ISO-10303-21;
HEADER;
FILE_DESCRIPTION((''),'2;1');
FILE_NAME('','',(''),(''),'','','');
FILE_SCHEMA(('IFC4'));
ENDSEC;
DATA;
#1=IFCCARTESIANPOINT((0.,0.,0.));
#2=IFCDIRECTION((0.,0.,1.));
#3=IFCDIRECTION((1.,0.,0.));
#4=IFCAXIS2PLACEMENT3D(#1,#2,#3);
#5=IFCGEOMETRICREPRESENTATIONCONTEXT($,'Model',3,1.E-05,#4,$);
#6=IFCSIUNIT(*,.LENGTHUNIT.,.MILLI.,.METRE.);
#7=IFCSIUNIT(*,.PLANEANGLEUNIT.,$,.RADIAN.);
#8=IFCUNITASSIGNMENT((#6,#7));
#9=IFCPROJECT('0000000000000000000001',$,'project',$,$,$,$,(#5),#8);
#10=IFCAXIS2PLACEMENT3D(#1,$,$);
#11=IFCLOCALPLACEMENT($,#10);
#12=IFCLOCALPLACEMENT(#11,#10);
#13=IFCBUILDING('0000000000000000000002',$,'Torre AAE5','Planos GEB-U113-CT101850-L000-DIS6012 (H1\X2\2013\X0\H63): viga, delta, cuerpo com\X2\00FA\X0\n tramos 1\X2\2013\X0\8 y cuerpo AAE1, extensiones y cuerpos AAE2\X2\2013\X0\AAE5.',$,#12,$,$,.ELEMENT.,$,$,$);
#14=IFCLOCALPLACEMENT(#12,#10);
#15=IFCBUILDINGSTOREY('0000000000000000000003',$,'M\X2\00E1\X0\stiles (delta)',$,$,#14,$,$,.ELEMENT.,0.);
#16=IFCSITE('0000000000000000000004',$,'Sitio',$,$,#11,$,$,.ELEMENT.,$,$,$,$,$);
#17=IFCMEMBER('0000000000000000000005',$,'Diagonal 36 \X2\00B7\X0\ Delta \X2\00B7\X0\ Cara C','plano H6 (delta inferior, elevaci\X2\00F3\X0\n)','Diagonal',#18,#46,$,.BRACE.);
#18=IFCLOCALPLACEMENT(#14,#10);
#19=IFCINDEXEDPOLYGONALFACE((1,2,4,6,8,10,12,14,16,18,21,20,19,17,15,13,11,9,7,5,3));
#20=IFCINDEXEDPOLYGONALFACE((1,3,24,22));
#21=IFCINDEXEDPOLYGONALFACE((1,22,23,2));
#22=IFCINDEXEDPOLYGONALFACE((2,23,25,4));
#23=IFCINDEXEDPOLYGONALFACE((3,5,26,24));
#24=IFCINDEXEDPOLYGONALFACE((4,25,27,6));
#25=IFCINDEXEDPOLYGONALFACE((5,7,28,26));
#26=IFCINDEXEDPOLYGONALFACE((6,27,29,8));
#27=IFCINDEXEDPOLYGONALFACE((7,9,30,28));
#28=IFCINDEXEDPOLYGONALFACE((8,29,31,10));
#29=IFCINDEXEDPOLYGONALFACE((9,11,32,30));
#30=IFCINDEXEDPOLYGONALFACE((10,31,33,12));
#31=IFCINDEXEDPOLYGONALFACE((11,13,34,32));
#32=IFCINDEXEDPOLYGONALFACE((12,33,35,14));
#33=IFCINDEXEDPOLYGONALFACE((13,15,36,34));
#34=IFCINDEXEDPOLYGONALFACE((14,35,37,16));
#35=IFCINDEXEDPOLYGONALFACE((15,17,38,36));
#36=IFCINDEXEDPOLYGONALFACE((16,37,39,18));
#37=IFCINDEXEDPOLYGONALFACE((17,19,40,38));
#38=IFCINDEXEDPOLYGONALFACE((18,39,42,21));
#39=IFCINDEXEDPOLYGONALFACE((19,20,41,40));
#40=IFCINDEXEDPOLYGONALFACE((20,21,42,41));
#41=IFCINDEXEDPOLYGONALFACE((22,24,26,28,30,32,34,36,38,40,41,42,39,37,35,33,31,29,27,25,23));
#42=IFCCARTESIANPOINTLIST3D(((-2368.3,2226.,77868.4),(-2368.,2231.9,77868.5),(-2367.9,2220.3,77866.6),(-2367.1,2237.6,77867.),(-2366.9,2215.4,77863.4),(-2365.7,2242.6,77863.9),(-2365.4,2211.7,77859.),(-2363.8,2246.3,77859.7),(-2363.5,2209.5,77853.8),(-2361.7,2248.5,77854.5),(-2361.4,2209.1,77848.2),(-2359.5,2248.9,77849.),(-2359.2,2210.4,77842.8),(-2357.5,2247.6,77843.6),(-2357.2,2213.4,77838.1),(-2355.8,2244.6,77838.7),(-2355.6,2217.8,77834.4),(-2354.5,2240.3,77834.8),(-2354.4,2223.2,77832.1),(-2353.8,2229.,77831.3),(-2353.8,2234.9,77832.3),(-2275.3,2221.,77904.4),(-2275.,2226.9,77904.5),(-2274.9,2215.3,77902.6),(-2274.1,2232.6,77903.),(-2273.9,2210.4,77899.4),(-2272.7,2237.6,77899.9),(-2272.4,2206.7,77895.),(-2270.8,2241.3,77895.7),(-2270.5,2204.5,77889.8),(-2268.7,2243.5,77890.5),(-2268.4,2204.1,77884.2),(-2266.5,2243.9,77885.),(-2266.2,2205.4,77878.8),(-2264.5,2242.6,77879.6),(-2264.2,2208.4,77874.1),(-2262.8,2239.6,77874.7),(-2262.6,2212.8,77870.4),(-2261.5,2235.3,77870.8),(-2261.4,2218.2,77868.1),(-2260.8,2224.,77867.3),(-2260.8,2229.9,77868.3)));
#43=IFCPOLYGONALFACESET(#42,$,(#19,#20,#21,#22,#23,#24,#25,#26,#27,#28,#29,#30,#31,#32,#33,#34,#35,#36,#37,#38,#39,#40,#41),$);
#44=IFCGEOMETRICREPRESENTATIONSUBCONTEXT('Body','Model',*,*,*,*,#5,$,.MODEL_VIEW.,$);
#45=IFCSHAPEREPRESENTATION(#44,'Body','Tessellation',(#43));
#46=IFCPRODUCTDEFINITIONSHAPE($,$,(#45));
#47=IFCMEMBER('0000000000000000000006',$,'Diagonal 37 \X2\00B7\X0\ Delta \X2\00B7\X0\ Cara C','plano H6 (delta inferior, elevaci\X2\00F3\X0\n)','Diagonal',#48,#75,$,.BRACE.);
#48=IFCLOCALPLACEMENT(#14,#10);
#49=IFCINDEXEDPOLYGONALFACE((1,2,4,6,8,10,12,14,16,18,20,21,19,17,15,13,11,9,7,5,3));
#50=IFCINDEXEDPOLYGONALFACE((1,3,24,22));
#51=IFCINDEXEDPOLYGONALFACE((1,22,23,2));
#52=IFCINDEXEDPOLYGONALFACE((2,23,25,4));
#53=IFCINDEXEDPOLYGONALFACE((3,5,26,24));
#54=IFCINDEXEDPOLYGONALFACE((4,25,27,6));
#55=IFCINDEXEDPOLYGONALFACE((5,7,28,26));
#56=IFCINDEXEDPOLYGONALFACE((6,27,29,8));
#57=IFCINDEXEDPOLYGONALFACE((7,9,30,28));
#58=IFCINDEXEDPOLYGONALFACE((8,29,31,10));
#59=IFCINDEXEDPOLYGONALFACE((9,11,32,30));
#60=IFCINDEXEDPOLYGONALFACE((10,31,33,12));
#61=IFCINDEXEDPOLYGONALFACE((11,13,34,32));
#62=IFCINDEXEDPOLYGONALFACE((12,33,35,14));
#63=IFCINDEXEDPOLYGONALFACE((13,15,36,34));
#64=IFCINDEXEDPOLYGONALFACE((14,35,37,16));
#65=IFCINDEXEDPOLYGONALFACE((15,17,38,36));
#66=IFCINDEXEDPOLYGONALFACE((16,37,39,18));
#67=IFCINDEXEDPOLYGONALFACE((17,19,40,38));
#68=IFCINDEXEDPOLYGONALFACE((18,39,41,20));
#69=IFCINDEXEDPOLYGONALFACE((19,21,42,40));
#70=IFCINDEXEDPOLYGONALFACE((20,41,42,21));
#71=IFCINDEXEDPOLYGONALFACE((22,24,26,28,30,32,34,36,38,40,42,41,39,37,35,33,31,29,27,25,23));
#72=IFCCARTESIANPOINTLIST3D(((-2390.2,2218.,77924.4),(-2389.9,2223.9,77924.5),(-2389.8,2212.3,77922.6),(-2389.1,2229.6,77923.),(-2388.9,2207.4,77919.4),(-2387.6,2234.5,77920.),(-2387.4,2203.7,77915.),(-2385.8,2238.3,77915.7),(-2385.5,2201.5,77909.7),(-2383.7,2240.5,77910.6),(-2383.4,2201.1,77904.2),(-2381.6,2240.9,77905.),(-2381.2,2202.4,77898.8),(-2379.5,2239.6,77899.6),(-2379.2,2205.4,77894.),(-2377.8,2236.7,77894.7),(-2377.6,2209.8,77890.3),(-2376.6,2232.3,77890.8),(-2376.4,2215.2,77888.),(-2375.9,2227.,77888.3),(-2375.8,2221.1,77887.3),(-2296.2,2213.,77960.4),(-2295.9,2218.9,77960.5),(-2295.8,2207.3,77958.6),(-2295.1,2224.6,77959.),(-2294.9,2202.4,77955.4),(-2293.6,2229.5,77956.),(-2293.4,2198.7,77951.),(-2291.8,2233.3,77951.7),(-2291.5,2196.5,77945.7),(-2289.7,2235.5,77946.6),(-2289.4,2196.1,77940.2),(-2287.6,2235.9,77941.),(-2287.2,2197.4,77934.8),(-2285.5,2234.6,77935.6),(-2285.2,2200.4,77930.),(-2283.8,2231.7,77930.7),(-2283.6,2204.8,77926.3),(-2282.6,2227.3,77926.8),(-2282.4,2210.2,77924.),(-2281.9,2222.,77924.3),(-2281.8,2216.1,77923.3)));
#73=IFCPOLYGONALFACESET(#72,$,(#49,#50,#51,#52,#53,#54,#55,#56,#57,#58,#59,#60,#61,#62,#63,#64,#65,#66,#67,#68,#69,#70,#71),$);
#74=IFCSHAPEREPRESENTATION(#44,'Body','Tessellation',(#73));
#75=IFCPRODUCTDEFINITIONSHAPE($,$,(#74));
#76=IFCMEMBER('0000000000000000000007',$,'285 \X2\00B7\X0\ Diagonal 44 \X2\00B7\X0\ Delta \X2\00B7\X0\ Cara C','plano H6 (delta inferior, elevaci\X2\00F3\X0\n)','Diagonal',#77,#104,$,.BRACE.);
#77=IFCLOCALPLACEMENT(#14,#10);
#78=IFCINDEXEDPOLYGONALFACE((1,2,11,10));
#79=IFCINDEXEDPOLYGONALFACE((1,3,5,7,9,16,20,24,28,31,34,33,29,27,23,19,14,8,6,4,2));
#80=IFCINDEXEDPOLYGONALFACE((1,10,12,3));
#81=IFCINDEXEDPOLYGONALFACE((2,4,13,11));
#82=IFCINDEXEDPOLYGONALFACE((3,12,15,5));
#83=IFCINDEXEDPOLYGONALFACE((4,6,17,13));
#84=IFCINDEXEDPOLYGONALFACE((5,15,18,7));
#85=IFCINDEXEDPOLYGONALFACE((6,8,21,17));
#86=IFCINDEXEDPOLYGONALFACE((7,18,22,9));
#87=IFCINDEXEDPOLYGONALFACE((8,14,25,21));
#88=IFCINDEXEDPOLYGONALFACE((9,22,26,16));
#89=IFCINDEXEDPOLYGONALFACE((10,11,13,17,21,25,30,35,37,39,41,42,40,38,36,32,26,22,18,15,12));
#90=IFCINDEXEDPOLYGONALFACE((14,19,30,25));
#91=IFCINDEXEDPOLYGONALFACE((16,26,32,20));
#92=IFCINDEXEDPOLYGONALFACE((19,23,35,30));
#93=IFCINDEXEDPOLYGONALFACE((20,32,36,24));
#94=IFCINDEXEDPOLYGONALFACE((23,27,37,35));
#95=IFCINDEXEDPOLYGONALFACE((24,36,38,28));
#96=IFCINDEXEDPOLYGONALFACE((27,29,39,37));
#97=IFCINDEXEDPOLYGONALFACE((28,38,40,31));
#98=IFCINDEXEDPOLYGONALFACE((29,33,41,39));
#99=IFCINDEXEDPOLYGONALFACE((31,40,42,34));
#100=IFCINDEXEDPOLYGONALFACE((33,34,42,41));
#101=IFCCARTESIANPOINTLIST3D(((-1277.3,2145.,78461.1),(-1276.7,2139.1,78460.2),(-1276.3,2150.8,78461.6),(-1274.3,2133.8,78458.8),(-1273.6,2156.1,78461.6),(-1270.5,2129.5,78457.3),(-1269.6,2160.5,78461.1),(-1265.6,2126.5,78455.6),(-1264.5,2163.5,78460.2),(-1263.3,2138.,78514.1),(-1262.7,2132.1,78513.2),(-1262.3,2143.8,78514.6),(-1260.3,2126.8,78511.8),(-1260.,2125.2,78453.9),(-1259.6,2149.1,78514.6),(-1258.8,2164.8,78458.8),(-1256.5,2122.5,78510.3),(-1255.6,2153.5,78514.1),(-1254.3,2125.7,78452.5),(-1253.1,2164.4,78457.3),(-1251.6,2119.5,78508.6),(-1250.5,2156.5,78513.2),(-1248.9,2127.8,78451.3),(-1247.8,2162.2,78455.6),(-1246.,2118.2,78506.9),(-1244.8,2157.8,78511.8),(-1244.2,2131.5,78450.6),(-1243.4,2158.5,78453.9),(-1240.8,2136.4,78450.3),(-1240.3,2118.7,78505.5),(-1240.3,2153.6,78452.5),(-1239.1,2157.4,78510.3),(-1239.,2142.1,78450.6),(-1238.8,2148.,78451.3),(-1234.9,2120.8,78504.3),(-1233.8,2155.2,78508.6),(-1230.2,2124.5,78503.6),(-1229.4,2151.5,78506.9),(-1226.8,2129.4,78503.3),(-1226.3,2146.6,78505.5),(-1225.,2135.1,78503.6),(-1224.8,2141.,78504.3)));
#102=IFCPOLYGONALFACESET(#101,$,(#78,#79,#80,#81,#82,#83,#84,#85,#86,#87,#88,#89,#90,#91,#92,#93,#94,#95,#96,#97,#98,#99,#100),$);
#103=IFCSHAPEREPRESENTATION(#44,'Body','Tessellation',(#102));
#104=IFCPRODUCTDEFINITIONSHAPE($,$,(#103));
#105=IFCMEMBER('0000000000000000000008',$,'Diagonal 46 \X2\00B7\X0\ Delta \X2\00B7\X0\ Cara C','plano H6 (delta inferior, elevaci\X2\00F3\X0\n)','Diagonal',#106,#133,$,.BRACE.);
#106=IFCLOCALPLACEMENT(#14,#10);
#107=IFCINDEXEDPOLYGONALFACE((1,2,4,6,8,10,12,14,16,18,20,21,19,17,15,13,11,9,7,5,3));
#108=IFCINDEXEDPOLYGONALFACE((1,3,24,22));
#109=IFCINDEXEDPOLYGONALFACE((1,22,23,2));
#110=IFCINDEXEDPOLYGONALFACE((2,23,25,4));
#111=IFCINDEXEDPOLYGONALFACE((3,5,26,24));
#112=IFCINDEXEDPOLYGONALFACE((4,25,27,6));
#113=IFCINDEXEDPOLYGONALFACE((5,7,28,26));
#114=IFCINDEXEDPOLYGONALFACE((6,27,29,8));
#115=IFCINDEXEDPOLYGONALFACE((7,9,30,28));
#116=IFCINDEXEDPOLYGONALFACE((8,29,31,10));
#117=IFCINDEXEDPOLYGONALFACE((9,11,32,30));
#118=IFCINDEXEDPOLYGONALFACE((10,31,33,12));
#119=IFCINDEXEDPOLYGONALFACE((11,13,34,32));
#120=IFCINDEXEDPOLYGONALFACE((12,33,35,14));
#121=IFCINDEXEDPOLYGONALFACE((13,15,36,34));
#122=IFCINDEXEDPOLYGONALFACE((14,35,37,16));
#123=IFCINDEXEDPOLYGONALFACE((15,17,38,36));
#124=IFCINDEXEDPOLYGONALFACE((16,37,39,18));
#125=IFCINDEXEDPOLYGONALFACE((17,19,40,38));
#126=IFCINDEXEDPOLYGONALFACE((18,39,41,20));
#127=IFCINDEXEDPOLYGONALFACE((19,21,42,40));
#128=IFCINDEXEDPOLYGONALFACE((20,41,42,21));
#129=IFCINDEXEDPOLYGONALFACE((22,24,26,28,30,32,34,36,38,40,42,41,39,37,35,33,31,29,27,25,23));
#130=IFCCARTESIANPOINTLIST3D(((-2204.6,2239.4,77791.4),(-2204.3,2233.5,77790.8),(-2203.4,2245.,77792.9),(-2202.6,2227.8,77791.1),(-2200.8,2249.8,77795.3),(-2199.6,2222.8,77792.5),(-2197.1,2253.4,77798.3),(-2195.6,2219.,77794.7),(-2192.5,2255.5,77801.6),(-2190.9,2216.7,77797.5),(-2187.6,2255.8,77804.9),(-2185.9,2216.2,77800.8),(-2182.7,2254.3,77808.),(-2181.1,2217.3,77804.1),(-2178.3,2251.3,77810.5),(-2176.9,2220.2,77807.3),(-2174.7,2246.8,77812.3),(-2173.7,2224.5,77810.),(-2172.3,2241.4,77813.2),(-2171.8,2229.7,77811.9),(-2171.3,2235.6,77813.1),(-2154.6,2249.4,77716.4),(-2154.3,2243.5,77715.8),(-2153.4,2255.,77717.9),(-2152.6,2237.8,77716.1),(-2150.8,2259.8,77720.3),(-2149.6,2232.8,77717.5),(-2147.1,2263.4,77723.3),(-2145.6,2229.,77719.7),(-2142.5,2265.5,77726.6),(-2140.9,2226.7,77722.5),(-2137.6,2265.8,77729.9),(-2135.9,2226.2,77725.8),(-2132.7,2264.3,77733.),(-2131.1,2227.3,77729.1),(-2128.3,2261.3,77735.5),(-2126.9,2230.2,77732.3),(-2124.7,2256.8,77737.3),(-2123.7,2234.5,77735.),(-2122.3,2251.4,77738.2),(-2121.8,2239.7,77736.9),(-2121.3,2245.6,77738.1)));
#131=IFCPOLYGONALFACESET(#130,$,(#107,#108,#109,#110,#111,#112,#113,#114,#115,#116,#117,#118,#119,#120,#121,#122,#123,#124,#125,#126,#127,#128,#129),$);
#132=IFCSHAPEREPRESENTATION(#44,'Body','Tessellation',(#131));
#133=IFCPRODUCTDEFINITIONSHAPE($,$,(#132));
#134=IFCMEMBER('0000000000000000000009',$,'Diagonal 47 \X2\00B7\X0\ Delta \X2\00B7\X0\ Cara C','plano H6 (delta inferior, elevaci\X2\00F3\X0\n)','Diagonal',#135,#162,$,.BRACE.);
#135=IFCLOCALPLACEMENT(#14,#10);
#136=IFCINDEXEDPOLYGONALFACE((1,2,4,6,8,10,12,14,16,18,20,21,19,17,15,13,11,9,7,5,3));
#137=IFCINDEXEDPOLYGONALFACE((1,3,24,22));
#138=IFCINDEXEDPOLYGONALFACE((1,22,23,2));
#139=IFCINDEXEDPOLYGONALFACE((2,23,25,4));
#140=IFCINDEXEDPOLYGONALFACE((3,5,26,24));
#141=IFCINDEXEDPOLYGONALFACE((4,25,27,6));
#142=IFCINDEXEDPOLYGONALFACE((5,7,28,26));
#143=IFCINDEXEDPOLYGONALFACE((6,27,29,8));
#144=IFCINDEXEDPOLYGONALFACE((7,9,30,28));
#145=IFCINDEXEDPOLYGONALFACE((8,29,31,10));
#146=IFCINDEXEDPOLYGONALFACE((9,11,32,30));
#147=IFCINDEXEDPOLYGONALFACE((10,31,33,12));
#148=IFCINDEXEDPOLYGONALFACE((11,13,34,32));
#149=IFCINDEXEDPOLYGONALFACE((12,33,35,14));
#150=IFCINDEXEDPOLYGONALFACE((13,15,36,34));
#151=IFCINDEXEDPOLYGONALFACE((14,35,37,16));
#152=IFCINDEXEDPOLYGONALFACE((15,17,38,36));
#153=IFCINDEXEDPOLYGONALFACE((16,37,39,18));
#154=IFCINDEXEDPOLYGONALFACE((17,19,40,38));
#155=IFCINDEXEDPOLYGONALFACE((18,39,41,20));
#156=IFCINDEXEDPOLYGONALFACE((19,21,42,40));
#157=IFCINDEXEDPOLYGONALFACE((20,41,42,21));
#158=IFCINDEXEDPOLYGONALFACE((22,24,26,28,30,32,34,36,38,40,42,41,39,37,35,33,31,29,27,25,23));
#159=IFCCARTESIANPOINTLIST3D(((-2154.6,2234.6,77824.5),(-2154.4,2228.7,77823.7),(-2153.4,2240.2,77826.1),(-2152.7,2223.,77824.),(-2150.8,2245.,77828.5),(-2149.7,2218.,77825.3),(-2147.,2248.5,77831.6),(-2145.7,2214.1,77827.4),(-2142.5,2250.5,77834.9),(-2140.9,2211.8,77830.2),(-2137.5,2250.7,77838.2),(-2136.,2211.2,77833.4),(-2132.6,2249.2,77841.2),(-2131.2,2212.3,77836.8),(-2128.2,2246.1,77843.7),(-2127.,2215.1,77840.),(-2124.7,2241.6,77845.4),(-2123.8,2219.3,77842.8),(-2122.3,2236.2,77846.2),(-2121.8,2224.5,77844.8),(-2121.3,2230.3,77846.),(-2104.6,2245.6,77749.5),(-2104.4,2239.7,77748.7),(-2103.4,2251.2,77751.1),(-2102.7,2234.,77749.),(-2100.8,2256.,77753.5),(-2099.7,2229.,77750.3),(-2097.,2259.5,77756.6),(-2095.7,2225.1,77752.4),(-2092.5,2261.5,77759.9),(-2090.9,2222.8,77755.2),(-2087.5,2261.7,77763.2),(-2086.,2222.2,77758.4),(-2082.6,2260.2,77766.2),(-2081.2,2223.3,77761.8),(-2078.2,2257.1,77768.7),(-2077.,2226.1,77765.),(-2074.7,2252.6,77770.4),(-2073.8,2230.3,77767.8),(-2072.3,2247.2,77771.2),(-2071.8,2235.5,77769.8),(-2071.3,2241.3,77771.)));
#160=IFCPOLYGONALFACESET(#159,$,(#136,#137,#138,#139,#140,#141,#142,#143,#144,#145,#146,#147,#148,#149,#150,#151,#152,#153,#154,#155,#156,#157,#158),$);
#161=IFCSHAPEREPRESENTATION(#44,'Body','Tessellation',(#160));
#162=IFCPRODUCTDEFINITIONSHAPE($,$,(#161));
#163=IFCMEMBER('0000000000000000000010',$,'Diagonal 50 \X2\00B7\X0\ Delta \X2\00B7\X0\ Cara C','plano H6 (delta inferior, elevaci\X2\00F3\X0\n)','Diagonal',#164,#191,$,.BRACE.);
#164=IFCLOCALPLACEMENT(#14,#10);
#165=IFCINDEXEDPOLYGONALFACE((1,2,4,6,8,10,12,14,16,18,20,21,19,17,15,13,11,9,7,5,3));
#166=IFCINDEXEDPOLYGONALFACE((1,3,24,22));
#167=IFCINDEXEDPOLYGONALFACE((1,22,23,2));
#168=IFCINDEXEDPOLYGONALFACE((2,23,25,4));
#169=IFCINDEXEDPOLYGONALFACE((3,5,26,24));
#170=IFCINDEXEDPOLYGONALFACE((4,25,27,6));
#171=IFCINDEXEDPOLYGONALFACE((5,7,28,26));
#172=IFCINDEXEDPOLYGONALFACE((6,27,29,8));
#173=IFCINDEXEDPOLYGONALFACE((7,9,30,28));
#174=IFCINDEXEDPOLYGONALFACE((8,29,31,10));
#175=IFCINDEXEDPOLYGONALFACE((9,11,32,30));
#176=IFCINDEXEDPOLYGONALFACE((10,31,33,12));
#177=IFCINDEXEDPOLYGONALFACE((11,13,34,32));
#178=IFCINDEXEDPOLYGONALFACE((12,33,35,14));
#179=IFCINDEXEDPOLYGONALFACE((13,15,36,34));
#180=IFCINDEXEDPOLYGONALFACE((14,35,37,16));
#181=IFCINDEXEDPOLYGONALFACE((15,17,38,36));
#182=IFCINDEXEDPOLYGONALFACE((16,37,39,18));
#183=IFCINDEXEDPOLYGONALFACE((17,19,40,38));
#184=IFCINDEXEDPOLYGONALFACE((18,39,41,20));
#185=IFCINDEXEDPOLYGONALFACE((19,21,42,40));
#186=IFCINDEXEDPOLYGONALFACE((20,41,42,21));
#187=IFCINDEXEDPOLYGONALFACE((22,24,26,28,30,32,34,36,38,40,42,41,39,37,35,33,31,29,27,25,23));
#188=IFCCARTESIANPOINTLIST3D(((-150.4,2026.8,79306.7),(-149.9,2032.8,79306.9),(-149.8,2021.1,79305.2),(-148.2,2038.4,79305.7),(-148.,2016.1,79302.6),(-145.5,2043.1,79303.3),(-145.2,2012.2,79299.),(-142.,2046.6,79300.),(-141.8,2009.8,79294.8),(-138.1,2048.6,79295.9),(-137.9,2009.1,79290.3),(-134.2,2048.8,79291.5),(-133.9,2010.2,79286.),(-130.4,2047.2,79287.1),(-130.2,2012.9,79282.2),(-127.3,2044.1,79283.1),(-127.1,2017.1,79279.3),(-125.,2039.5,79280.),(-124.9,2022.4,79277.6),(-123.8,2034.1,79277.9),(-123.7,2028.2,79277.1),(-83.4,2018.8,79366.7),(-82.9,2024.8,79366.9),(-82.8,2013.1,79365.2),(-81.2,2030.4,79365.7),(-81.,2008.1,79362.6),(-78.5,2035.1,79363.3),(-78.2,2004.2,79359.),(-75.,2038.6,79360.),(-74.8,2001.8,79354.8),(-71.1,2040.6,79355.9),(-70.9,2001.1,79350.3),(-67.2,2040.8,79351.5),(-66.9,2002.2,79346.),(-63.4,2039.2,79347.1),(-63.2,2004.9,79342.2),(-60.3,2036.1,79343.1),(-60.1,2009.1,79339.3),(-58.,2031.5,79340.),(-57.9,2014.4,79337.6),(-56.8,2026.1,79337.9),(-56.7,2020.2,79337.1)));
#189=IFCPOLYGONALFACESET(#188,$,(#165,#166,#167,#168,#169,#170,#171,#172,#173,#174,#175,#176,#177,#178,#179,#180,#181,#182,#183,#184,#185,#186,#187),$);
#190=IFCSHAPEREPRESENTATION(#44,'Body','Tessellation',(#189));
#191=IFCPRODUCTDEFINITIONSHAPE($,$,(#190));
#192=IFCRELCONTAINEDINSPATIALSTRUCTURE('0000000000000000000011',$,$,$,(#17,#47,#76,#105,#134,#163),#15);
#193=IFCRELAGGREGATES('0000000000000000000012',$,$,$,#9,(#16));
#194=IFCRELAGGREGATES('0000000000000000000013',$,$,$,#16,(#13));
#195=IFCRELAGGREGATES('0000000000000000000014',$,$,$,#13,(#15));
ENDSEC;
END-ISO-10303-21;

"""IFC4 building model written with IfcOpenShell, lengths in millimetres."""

from ifc_helpers import new_model, si_unit, frame, origin, origin_with_axes, place, context, subcontext, project, spatial, circle, extrude, element, save


model = new_model("IFC4")

# Units and contexts
model_context = context("Model", 3, precision=1e-05, world=origin_with_axes())
body_context = subcontext(model_context, "Body", "Model", "MODEL_VIEW")
ifc_project = project(units=[si_unit("LENGTHUNIT", "METRE", prefix="MILLI"), si_unit("PLANEANGLEUNIT", "RADIAN")], contexts=[model_context])

# Site, building, storey
site_placement = place(None, origin())
site = spatial("IfcSite", under=ifc_project, at=site_placement, Name="Sitio", CompositionType="ELEMENT")
building_placement = place(site_placement, origin())
building = spatial("IfcBuilding", under=site, at=building_placement, Name="Torre AAE5", Description="Planos GEB-U113-CT101850-L000-DIS6012 (H1–H63): viga, delta, cuerpo común tramos 1–8 y cuerpo AAE1, extensiones y cuerpos AAE2–AAE5.", CompositionType="ELEMENT")
storey_placement = place(building_placement, origin())
storey = spatial("IfcBuildingStorey", under=building, at=storey_placement, Name="Mástiles (delta)", CompositionType="ELEMENT", Elevation=0.0)

# Members
member_1_placement = place(storey_placement, frame((-2361.0, 2229.0, 77850.0), z_axis=(0.931398, -0.050075, 0.360541), x_axis=(0.089167, -0.928927, -0.359365)))
element("IfcMember", 1, at=member_1_placement, inside=storey, Name="Diagonal 36 · Delta · Cara C", Description="plano H6 (delta inferior, elevación)", ObjectType="Diagonal", PredefinedType="BRACE", context=body_context, shape_type="SweptSolid", body=[
    extrude(circle(Radius=20.0), None, (0.0, 0.0, 1.0), 99.8),
])
member_2_placement = place(storey_placement, frame((-2383.0, 2221.0, 77906.0), z_axis=(0.932707, -0.049612, 0.357207), x_axis=(0.088729, -0.928476, -0.360637)))
element("IfcMember", 2, at=member_2_placement, inside=storey, Name="Diagonal 37 · Delta · Cara C", Description="plano H6 (delta inferior, elevación)", ObjectType="Diagonal", PredefinedType="BRACE", context=body_context, shape_type="SweptSolid", body=[
    extrude(circle(Radius=20.0), None, (0.0, 0.0, 1.0), 100.8),
])
member_3_placement = place(storey_placement, frame((-1258.0, 2145.0, 78456.0), z_axis=(0.253334, -0.126667, 0.95905), x_axis=(0.457378, -0.857899, -0.234124)))
element("IfcMember", 3, at=member_3_placement, inside=storey, Name="285 · Diagonal 44 · Delta · Cara C", Description="plano H6 (delta inferior, elevación)", ObjectType="Diagonal", PredefinedType="BRACE", context=body_context, shape_type="SweptSolid", body=[
    extrude(circle(Radius=20.0), None, (0.0, 0.0, 1.0), 55.3),
])
member_4_placement = place(storey_placement, frame((-2138.0, 2246.0, 77727.0), z_axis=(-0.551318, -0.110264, 0.826977), x_axis=(0.553229, -0.790273, 0.26345)))
element("IfcMember", 4, at=member_4_placement, inside=storey, Name="Diagonal 46 · Delta · Cara C", Description="plano H6 (delta inferior, elevación)", ObjectType="Diagonal", PredefinedType="BRACE", context=body_context, shape_type="SweptSolid", body=[
    extrude(circle(Radius=20.0), None, (0.0, 0.0, 1.0), 90.7),
])
member_5_placement = place(storey_placement, frame((-2088.0, 2242.0, 77760.0), z_axis=(-0.550615, -0.121135, 0.825923), x_axis=(0.550707, -0.79627, 0.250352)))
element("IfcMember", 5, at=member_5_placement, inside=storey, Name="Diagonal 47 · Delta · Cara C", Description="plano H6 (delta inferior, elevación)", ObjectType="Diagonal", PredefinedType="BRACE", context=body_context, shape_type="SweptSolid", body=[
    extrude(circle(Radius=20.0), None, (0.0, 0.0, 1.0), 90.8),
])
member_6_placement = place(storey_placement, frame((-137.0, 2029.0, 79292.0), z_axis=(0.742021, -0.088599, 0.664496), x_axis=(-0.043062, -0.99548, -0.084644)))
element("IfcMember", 6, at=member_6_placement, inside=storey, Name="Diagonal 50 · Delta · Cara C", Description="plano H6 (delta inferior, elevación)", ObjectType="Diagonal", PredefinedType="BRACE", context=body_context, shape_type="SweptSolid", body=[
    extrude(circle(Radius=20.0), None, (0.0, 0.0, 1.0), 90.3),
])

save(model, "model.ifc")
